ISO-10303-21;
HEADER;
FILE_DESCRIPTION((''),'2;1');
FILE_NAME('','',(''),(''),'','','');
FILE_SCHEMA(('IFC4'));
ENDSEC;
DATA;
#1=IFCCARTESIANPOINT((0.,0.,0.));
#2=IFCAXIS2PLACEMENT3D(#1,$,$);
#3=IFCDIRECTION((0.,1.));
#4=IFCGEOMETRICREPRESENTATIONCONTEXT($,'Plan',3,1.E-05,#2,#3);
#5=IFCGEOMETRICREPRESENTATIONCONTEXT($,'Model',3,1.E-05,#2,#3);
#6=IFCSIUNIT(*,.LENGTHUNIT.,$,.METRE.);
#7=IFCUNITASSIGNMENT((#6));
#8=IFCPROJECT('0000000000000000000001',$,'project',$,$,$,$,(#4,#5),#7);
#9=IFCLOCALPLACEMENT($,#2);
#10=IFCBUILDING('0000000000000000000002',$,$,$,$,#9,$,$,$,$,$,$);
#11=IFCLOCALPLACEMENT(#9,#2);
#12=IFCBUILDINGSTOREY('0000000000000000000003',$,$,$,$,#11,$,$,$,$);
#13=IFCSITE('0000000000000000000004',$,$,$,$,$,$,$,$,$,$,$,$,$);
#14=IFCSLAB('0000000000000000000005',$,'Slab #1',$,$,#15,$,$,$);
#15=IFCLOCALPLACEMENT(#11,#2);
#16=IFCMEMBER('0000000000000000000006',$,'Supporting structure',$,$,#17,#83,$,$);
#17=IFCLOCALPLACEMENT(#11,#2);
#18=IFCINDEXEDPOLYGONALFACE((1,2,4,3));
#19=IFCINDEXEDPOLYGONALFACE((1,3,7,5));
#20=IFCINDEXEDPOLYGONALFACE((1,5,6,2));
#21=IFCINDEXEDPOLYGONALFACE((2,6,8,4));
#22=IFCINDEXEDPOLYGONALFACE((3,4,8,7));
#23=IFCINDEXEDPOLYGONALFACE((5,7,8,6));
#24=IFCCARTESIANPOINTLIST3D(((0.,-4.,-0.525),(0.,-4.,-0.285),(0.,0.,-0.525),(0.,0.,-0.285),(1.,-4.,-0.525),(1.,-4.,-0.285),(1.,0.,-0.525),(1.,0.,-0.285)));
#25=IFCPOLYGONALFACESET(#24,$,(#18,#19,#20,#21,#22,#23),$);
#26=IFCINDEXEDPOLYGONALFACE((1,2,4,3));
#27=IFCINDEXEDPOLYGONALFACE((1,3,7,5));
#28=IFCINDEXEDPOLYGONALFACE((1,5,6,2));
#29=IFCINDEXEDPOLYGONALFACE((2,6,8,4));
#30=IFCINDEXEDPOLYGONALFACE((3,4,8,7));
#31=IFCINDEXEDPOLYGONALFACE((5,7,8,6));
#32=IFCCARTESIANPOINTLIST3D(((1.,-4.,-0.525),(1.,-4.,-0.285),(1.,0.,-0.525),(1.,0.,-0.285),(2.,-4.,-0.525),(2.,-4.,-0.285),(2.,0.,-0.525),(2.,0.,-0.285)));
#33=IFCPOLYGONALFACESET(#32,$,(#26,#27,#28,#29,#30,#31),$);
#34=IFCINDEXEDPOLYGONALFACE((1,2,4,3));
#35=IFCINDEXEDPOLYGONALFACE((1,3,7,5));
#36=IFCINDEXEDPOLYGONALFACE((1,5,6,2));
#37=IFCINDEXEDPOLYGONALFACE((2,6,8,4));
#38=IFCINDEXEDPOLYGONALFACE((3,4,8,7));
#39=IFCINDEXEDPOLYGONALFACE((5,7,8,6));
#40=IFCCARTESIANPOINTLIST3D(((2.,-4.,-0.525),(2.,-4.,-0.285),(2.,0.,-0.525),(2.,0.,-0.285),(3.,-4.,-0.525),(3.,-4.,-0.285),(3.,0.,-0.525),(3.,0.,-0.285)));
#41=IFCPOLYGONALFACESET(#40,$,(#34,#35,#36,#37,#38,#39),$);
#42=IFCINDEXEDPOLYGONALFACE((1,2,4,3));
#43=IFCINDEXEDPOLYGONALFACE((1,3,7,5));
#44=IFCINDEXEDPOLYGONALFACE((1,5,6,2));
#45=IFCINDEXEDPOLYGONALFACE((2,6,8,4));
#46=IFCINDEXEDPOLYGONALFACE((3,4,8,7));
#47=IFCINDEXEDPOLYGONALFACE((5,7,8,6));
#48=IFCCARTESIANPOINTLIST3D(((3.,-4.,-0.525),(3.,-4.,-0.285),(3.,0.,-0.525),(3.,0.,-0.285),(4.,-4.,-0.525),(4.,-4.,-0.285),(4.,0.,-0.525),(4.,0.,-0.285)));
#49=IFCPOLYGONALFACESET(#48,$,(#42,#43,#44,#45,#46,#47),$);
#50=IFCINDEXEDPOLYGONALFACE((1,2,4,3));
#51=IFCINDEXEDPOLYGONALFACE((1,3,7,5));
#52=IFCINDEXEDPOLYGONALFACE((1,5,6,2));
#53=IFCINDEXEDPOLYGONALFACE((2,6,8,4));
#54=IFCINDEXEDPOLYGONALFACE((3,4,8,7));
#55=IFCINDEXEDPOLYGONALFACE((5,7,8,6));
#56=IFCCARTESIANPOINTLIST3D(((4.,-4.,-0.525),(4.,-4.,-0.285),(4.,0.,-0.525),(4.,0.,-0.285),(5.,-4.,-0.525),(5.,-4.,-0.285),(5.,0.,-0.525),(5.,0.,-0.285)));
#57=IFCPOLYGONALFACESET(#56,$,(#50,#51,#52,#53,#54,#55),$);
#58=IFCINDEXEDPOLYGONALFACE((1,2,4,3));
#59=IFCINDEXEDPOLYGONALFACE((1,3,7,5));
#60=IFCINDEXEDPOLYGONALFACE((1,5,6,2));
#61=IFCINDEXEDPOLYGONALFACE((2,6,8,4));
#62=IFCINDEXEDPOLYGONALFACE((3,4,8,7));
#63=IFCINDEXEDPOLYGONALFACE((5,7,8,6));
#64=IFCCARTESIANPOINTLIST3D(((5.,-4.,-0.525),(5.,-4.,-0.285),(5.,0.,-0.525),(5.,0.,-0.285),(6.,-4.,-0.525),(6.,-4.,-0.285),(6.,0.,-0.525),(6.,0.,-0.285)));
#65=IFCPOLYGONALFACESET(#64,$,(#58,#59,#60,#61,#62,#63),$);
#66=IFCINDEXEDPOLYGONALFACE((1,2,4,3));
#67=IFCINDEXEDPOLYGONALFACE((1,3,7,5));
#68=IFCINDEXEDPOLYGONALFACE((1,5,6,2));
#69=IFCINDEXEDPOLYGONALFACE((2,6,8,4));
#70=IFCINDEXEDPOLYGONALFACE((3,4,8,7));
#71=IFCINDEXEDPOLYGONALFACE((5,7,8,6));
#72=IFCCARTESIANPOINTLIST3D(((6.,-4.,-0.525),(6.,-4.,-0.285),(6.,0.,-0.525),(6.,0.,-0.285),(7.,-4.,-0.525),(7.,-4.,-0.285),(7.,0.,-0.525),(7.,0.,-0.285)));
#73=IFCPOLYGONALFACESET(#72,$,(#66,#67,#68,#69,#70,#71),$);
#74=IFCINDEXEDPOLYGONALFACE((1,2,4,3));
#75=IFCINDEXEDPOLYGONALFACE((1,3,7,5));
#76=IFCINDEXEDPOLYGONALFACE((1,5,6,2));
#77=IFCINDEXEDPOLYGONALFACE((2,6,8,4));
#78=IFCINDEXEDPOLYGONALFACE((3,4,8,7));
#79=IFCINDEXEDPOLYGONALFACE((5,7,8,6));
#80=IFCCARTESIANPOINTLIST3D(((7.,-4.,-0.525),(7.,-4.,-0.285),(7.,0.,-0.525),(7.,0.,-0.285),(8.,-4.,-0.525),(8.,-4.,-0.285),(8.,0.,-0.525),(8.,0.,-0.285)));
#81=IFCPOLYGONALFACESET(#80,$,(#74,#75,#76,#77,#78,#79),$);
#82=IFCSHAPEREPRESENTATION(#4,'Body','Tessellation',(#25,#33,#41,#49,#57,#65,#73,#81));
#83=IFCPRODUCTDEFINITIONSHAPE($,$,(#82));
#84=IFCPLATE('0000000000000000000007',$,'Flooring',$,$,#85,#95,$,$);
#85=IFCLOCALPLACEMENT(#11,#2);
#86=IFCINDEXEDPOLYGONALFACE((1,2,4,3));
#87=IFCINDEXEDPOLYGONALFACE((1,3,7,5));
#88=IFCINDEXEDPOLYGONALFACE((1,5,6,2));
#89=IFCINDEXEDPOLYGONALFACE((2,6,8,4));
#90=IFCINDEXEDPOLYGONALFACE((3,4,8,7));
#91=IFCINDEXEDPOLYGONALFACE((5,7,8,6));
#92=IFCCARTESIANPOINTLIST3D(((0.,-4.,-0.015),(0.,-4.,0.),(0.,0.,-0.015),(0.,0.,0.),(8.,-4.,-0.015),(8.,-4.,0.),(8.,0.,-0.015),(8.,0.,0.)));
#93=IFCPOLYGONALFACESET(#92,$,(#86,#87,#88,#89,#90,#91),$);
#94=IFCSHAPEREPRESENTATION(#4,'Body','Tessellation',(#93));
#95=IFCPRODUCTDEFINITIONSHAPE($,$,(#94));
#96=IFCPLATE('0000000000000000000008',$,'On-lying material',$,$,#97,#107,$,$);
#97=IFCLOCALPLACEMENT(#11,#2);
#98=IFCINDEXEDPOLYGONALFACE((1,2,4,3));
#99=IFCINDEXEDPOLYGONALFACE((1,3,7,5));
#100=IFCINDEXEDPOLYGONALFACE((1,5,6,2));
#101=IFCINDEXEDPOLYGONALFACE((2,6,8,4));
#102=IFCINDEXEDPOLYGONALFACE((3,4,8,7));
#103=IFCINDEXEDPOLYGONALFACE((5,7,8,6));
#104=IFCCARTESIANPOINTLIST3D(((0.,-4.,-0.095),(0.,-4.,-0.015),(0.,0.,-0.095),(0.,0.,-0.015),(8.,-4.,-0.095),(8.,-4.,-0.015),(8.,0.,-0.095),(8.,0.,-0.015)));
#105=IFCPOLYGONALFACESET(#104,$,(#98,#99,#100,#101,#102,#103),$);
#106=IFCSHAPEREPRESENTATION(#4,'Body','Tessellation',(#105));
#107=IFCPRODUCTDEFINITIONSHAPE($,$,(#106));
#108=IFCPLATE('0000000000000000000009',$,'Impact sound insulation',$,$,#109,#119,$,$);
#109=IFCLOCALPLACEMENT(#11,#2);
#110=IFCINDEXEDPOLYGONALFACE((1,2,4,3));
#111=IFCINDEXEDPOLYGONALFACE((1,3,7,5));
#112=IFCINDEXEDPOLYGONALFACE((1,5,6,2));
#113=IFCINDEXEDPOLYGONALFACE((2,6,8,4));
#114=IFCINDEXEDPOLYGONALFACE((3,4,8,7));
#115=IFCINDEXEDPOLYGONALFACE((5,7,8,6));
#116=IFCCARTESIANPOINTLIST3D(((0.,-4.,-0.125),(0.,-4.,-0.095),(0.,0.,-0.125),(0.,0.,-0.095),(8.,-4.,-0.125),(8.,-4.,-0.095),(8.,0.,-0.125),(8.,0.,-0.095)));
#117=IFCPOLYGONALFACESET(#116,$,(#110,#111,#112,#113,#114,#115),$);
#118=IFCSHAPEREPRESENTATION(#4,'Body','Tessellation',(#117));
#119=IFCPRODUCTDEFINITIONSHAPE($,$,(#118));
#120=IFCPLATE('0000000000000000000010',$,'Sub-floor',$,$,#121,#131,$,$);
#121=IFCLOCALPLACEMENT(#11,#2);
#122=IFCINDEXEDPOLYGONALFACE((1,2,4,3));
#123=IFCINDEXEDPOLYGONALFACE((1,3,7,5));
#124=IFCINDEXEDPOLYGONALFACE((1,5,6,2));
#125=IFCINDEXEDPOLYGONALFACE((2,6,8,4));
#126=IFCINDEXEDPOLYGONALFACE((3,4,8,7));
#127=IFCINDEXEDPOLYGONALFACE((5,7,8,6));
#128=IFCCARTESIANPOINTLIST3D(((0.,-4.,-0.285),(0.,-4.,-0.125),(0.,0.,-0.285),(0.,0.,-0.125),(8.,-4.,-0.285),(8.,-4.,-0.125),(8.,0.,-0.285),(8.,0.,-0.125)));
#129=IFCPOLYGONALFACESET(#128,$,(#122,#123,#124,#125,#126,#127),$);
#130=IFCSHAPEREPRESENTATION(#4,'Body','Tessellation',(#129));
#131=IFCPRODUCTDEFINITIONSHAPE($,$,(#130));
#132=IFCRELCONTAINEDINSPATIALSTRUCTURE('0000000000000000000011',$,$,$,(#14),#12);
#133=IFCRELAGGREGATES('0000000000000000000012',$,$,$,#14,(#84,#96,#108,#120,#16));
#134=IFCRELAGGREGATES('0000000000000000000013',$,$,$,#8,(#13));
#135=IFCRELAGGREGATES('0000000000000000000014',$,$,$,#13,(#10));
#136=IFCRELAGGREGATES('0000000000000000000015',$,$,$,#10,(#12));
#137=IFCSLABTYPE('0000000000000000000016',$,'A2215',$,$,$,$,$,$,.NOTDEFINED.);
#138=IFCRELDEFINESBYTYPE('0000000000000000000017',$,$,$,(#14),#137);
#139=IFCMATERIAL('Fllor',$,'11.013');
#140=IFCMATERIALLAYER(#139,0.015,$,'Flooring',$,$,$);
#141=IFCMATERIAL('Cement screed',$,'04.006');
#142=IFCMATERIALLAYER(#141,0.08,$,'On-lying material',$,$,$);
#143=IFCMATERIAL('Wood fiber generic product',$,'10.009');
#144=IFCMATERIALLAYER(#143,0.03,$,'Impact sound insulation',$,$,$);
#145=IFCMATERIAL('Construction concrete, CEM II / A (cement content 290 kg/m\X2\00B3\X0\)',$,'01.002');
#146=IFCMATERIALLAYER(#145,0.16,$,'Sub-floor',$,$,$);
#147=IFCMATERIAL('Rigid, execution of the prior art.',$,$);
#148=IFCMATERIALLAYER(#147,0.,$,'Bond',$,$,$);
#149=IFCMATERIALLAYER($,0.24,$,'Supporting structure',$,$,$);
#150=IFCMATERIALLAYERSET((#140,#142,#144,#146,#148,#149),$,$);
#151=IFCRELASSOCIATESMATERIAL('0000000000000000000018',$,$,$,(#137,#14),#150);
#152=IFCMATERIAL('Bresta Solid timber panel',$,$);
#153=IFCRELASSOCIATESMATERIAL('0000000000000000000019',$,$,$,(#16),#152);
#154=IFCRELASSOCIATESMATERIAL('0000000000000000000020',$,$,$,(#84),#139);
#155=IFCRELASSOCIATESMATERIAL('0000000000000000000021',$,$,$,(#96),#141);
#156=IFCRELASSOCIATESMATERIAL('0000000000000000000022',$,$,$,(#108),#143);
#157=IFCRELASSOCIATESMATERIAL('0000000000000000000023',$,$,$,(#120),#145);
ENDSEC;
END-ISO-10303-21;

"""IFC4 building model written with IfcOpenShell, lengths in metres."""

from ifc_helpers import new_model, si_unit, direction, frame, frame_2d, origin, origin_with_axes, place, context, project, spatial, rectangle, extrude, material, layer, layer_set, type_object, element, aggregate, save


model = new_model("IFC4")

# Units and contexts
plan_context = context("Plan", 3, precision=1e-05, world=origin(), true_north=direction((0.0, 1.0)))
model_context = context("Model", 3, precision=1e-05, world=origin(), true_north=direction((0.0, 1.0)))
ifc_project = project(units=[si_unit("LENGTHUNIT", "METRE")], contexts=[plan_context, model_context])

# Site, building, storey
site = spatial("IfcSite", under=ifc_project)
building_placement = place(None, origin())
building = spatial("IfcBuilding", under=site, at=building_placement)
storey_placement = place(building_placement, origin())
storey = spatial("IfcBuildingStorey", under=building, at=storey_placement)

# Slab, member, plates
ifc_material_1 = material(Name="Fllor", Category="11.013")
ifc_layer_1 = layer(ifc_material_1, 0.015, Name="Flooring")
ifc_material_2 = material(Name="Cement screed", Category="04.006")
ifc_layer_2 = layer(ifc_material_2, 0.08, Name="On-lying material")
ifc_material_3 = material(Name="Wood fiber generic product", Category="10.009")
ifc_layer_3 = layer(ifc_material_3, 0.03, Name="Impact sound insulation")
ifc_material_4 = material(Name="Construction concrete, CEM II / A (cement content 290 kg/m³)", Category="01.002")
ifc_layer_4 = layer(ifc_material_4, 0.16, Name="Sub-floor")
ifc_material_5 = material(Name="Rigid, execution of the prior art.")
ifc_layer_5 = layer(ifc_material_5, 0.0, Name="Bond")
ifc_layer_6 = layer(None, 0.24, Name="Supporting structure")
ifc_layer_set = layer_set([ifc_layer_1, ifc_layer_2, ifc_layer_3, ifc_layer_4, ifc_layer_5, ifc_layer_6])
slab_type = type_object("IfcSlabType", Name="A2215", PredefinedType="NOTDEFINED", material=ifc_layer_set)
slab_placement = place(None, frame((0.0, 0.0, 0.0), z_axis=(0.0, 0.0, -1.0), x_axis=(1.0, 0.0, 0.0)))
slab = element("IfcSlab", 1, at=slab_placement, inside=storey, type_object=slab_type, material=ifc_layer_set, Name="Slab #1")
ifc_material_6 = material(Name="Bresta Solid timber panel")
member_placement = place(slab_placement, origin())
member = element("IfcMember", 2, at=member_placement, material=ifc_material_6, Name="Supporting structure", context=plan_context, shape_type="SweptSolid", body=[
    extrude(rectangle(XDim=1.0, YDim=0.24, at=frame_2d((0.5, 0.12), x_axis=(1.0, 0.0))), frame((0.0, 4.0, 0.285), z_axis=(0.0, -1.0, 0.0), x_axis=(1.0, 0.0, 0.0)), (0.0, 0.0, 1.0), 4.0),
    extrude(rectangle(XDim=1.0, YDim=0.24, at=frame_2d((0.5, 0.12), x_axis=(1.0, 0.0))), frame((1.0, 4.0, 0.285), z_axis=(0.0, -1.0, 0.0), x_axis=(1.0, 0.0, 0.0)), (0.0, 0.0, 1.0), 4.0),
    extrude(rectangle(XDim=1.0, YDim=0.24, at=frame_2d((0.5, 0.12), x_axis=(1.0, 0.0))), frame((2.0, 4.0, 0.285), z_axis=(0.0, -1.0, 0.0), x_axis=(1.0, 0.0, 0.0)), (0.0, 0.0, 1.0), 4.0),
    extrude(rectangle(XDim=1.0, YDim=0.24, at=frame_2d((0.5, 0.12), x_axis=(1.0, 0.0))), frame((3.0, 4.0, 0.285), z_axis=(0.0, -1.0, 0.0), x_axis=(1.0, 0.0, 0.0)), (0.0, 0.0, 1.0), 4.0),
    extrude(rectangle(XDim=1.0, YDim=0.24, at=frame_2d((0.5, 0.12), x_axis=(1.0, 0.0))), frame((4.0, 4.0, 0.285), z_axis=(0.0, -1.0, 0.0), x_axis=(1.0, 0.0, 0.0)), (0.0, 0.0, 1.0), 4.0),
    extrude(rectangle(XDim=1.0, YDim=0.24, at=frame_2d((0.5, 0.12), x_axis=(1.0, 0.0))), frame((5.0, 4.0, 0.285), z_axis=(0.0, -1.0, 0.0), x_axis=(1.0, 0.0, 0.0)), (0.0, 0.0, 1.0), 4.0),
    extrude(rectangle(XDim=1.0, YDim=0.24, at=frame_2d((0.5, 0.12), x_axis=(1.0, 0.0))), frame((6.0, 4.0, 0.285), z_axis=(0.0, -1.0, 0.0), x_axis=(1.0, 0.0, 0.0)), (0.0, 0.0, 1.0), 4.0),
    extrude(rectangle(XDim=1.0, YDim=0.24, at=frame_2d((0.5, 0.12), x_axis=(1.0, 0.0))), frame((7.0, 4.0, 0.285), z_axis=(0.0, -1.0, 0.0), x_axis=(1.0, 0.0, 0.0)), (0.0, 0.0, 1.0), 4.0),
])
plate_1_placement = place(slab_placement, origin())
plate_1 = element("IfcPlate", 3, at=plate_1_placement, material=ifc_material_1, Name="Flooring", context=plan_context, shape_type="SweptSolid", body=[
    extrude(rectangle(XDim=8.0, YDim=4.0, at=frame_2d((4.0, 2.0), x_axis=(1.0, 0.0))), origin_with_axes(), (0.0, 0.0, 1.0), 0.015),
])
plate_2_placement = place(slab_placement, origin())
plate_2 = element("IfcPlate", 4, at=plate_2_placement, material=ifc_material_2, Name="On-lying material", context=plan_context, shape_type="SweptSolid", body=[
    extrude(rectangle(XDim=8.0, YDim=4.0, at=frame_2d((4.0, 2.0), x_axis=(1.0, 0.0))), frame((0.0, 0.0, 0.015), z_axis=(0.0, 0.0, 1.0), x_axis=(1.0, 0.0, 0.0)), (0.0, 0.0, 1.0), 0.08),
])
plate_3_placement = place(slab_placement, origin())
plate_3 = element("IfcPlate", 5, at=plate_3_placement, material=ifc_material_3, Name="Impact sound insulation", context=plan_context, shape_type="SweptSolid", body=[
    extrude(rectangle(XDim=8.0, YDim=4.0, at=frame_2d((4.0, 2.0), x_axis=(1.0, 0.0))), frame((0.0, 0.0, 0.095), z_axis=(0.0, 0.0, 1.0), x_axis=(1.0, 0.0, 0.0)), (0.0, 0.0, 1.0), 0.03),
])
plate_4_placement = place(slab_placement, origin())
plate_4 = element("IfcPlate", 6, at=plate_4_placement, material=ifc_material_4, Name="Sub-floor", context=plan_context, shape_type="SweptSolid", body=[
    extrude(rectangle(XDim=8.0, YDim=4.0, at=frame_2d((4.0, 2.0), x_axis=(1.0, 0.0))), frame((0.0, 0.0, 0.125), z_axis=(0.0, 0.0, 1.0), x_axis=(1.0, 0.0, 0.0)), (0.0, 0.0, 1.0), 0.16),
])
aggregate(slab, [plate_1, plate_2, plate_3, plate_4, member])

save(model, "model.ifc")
